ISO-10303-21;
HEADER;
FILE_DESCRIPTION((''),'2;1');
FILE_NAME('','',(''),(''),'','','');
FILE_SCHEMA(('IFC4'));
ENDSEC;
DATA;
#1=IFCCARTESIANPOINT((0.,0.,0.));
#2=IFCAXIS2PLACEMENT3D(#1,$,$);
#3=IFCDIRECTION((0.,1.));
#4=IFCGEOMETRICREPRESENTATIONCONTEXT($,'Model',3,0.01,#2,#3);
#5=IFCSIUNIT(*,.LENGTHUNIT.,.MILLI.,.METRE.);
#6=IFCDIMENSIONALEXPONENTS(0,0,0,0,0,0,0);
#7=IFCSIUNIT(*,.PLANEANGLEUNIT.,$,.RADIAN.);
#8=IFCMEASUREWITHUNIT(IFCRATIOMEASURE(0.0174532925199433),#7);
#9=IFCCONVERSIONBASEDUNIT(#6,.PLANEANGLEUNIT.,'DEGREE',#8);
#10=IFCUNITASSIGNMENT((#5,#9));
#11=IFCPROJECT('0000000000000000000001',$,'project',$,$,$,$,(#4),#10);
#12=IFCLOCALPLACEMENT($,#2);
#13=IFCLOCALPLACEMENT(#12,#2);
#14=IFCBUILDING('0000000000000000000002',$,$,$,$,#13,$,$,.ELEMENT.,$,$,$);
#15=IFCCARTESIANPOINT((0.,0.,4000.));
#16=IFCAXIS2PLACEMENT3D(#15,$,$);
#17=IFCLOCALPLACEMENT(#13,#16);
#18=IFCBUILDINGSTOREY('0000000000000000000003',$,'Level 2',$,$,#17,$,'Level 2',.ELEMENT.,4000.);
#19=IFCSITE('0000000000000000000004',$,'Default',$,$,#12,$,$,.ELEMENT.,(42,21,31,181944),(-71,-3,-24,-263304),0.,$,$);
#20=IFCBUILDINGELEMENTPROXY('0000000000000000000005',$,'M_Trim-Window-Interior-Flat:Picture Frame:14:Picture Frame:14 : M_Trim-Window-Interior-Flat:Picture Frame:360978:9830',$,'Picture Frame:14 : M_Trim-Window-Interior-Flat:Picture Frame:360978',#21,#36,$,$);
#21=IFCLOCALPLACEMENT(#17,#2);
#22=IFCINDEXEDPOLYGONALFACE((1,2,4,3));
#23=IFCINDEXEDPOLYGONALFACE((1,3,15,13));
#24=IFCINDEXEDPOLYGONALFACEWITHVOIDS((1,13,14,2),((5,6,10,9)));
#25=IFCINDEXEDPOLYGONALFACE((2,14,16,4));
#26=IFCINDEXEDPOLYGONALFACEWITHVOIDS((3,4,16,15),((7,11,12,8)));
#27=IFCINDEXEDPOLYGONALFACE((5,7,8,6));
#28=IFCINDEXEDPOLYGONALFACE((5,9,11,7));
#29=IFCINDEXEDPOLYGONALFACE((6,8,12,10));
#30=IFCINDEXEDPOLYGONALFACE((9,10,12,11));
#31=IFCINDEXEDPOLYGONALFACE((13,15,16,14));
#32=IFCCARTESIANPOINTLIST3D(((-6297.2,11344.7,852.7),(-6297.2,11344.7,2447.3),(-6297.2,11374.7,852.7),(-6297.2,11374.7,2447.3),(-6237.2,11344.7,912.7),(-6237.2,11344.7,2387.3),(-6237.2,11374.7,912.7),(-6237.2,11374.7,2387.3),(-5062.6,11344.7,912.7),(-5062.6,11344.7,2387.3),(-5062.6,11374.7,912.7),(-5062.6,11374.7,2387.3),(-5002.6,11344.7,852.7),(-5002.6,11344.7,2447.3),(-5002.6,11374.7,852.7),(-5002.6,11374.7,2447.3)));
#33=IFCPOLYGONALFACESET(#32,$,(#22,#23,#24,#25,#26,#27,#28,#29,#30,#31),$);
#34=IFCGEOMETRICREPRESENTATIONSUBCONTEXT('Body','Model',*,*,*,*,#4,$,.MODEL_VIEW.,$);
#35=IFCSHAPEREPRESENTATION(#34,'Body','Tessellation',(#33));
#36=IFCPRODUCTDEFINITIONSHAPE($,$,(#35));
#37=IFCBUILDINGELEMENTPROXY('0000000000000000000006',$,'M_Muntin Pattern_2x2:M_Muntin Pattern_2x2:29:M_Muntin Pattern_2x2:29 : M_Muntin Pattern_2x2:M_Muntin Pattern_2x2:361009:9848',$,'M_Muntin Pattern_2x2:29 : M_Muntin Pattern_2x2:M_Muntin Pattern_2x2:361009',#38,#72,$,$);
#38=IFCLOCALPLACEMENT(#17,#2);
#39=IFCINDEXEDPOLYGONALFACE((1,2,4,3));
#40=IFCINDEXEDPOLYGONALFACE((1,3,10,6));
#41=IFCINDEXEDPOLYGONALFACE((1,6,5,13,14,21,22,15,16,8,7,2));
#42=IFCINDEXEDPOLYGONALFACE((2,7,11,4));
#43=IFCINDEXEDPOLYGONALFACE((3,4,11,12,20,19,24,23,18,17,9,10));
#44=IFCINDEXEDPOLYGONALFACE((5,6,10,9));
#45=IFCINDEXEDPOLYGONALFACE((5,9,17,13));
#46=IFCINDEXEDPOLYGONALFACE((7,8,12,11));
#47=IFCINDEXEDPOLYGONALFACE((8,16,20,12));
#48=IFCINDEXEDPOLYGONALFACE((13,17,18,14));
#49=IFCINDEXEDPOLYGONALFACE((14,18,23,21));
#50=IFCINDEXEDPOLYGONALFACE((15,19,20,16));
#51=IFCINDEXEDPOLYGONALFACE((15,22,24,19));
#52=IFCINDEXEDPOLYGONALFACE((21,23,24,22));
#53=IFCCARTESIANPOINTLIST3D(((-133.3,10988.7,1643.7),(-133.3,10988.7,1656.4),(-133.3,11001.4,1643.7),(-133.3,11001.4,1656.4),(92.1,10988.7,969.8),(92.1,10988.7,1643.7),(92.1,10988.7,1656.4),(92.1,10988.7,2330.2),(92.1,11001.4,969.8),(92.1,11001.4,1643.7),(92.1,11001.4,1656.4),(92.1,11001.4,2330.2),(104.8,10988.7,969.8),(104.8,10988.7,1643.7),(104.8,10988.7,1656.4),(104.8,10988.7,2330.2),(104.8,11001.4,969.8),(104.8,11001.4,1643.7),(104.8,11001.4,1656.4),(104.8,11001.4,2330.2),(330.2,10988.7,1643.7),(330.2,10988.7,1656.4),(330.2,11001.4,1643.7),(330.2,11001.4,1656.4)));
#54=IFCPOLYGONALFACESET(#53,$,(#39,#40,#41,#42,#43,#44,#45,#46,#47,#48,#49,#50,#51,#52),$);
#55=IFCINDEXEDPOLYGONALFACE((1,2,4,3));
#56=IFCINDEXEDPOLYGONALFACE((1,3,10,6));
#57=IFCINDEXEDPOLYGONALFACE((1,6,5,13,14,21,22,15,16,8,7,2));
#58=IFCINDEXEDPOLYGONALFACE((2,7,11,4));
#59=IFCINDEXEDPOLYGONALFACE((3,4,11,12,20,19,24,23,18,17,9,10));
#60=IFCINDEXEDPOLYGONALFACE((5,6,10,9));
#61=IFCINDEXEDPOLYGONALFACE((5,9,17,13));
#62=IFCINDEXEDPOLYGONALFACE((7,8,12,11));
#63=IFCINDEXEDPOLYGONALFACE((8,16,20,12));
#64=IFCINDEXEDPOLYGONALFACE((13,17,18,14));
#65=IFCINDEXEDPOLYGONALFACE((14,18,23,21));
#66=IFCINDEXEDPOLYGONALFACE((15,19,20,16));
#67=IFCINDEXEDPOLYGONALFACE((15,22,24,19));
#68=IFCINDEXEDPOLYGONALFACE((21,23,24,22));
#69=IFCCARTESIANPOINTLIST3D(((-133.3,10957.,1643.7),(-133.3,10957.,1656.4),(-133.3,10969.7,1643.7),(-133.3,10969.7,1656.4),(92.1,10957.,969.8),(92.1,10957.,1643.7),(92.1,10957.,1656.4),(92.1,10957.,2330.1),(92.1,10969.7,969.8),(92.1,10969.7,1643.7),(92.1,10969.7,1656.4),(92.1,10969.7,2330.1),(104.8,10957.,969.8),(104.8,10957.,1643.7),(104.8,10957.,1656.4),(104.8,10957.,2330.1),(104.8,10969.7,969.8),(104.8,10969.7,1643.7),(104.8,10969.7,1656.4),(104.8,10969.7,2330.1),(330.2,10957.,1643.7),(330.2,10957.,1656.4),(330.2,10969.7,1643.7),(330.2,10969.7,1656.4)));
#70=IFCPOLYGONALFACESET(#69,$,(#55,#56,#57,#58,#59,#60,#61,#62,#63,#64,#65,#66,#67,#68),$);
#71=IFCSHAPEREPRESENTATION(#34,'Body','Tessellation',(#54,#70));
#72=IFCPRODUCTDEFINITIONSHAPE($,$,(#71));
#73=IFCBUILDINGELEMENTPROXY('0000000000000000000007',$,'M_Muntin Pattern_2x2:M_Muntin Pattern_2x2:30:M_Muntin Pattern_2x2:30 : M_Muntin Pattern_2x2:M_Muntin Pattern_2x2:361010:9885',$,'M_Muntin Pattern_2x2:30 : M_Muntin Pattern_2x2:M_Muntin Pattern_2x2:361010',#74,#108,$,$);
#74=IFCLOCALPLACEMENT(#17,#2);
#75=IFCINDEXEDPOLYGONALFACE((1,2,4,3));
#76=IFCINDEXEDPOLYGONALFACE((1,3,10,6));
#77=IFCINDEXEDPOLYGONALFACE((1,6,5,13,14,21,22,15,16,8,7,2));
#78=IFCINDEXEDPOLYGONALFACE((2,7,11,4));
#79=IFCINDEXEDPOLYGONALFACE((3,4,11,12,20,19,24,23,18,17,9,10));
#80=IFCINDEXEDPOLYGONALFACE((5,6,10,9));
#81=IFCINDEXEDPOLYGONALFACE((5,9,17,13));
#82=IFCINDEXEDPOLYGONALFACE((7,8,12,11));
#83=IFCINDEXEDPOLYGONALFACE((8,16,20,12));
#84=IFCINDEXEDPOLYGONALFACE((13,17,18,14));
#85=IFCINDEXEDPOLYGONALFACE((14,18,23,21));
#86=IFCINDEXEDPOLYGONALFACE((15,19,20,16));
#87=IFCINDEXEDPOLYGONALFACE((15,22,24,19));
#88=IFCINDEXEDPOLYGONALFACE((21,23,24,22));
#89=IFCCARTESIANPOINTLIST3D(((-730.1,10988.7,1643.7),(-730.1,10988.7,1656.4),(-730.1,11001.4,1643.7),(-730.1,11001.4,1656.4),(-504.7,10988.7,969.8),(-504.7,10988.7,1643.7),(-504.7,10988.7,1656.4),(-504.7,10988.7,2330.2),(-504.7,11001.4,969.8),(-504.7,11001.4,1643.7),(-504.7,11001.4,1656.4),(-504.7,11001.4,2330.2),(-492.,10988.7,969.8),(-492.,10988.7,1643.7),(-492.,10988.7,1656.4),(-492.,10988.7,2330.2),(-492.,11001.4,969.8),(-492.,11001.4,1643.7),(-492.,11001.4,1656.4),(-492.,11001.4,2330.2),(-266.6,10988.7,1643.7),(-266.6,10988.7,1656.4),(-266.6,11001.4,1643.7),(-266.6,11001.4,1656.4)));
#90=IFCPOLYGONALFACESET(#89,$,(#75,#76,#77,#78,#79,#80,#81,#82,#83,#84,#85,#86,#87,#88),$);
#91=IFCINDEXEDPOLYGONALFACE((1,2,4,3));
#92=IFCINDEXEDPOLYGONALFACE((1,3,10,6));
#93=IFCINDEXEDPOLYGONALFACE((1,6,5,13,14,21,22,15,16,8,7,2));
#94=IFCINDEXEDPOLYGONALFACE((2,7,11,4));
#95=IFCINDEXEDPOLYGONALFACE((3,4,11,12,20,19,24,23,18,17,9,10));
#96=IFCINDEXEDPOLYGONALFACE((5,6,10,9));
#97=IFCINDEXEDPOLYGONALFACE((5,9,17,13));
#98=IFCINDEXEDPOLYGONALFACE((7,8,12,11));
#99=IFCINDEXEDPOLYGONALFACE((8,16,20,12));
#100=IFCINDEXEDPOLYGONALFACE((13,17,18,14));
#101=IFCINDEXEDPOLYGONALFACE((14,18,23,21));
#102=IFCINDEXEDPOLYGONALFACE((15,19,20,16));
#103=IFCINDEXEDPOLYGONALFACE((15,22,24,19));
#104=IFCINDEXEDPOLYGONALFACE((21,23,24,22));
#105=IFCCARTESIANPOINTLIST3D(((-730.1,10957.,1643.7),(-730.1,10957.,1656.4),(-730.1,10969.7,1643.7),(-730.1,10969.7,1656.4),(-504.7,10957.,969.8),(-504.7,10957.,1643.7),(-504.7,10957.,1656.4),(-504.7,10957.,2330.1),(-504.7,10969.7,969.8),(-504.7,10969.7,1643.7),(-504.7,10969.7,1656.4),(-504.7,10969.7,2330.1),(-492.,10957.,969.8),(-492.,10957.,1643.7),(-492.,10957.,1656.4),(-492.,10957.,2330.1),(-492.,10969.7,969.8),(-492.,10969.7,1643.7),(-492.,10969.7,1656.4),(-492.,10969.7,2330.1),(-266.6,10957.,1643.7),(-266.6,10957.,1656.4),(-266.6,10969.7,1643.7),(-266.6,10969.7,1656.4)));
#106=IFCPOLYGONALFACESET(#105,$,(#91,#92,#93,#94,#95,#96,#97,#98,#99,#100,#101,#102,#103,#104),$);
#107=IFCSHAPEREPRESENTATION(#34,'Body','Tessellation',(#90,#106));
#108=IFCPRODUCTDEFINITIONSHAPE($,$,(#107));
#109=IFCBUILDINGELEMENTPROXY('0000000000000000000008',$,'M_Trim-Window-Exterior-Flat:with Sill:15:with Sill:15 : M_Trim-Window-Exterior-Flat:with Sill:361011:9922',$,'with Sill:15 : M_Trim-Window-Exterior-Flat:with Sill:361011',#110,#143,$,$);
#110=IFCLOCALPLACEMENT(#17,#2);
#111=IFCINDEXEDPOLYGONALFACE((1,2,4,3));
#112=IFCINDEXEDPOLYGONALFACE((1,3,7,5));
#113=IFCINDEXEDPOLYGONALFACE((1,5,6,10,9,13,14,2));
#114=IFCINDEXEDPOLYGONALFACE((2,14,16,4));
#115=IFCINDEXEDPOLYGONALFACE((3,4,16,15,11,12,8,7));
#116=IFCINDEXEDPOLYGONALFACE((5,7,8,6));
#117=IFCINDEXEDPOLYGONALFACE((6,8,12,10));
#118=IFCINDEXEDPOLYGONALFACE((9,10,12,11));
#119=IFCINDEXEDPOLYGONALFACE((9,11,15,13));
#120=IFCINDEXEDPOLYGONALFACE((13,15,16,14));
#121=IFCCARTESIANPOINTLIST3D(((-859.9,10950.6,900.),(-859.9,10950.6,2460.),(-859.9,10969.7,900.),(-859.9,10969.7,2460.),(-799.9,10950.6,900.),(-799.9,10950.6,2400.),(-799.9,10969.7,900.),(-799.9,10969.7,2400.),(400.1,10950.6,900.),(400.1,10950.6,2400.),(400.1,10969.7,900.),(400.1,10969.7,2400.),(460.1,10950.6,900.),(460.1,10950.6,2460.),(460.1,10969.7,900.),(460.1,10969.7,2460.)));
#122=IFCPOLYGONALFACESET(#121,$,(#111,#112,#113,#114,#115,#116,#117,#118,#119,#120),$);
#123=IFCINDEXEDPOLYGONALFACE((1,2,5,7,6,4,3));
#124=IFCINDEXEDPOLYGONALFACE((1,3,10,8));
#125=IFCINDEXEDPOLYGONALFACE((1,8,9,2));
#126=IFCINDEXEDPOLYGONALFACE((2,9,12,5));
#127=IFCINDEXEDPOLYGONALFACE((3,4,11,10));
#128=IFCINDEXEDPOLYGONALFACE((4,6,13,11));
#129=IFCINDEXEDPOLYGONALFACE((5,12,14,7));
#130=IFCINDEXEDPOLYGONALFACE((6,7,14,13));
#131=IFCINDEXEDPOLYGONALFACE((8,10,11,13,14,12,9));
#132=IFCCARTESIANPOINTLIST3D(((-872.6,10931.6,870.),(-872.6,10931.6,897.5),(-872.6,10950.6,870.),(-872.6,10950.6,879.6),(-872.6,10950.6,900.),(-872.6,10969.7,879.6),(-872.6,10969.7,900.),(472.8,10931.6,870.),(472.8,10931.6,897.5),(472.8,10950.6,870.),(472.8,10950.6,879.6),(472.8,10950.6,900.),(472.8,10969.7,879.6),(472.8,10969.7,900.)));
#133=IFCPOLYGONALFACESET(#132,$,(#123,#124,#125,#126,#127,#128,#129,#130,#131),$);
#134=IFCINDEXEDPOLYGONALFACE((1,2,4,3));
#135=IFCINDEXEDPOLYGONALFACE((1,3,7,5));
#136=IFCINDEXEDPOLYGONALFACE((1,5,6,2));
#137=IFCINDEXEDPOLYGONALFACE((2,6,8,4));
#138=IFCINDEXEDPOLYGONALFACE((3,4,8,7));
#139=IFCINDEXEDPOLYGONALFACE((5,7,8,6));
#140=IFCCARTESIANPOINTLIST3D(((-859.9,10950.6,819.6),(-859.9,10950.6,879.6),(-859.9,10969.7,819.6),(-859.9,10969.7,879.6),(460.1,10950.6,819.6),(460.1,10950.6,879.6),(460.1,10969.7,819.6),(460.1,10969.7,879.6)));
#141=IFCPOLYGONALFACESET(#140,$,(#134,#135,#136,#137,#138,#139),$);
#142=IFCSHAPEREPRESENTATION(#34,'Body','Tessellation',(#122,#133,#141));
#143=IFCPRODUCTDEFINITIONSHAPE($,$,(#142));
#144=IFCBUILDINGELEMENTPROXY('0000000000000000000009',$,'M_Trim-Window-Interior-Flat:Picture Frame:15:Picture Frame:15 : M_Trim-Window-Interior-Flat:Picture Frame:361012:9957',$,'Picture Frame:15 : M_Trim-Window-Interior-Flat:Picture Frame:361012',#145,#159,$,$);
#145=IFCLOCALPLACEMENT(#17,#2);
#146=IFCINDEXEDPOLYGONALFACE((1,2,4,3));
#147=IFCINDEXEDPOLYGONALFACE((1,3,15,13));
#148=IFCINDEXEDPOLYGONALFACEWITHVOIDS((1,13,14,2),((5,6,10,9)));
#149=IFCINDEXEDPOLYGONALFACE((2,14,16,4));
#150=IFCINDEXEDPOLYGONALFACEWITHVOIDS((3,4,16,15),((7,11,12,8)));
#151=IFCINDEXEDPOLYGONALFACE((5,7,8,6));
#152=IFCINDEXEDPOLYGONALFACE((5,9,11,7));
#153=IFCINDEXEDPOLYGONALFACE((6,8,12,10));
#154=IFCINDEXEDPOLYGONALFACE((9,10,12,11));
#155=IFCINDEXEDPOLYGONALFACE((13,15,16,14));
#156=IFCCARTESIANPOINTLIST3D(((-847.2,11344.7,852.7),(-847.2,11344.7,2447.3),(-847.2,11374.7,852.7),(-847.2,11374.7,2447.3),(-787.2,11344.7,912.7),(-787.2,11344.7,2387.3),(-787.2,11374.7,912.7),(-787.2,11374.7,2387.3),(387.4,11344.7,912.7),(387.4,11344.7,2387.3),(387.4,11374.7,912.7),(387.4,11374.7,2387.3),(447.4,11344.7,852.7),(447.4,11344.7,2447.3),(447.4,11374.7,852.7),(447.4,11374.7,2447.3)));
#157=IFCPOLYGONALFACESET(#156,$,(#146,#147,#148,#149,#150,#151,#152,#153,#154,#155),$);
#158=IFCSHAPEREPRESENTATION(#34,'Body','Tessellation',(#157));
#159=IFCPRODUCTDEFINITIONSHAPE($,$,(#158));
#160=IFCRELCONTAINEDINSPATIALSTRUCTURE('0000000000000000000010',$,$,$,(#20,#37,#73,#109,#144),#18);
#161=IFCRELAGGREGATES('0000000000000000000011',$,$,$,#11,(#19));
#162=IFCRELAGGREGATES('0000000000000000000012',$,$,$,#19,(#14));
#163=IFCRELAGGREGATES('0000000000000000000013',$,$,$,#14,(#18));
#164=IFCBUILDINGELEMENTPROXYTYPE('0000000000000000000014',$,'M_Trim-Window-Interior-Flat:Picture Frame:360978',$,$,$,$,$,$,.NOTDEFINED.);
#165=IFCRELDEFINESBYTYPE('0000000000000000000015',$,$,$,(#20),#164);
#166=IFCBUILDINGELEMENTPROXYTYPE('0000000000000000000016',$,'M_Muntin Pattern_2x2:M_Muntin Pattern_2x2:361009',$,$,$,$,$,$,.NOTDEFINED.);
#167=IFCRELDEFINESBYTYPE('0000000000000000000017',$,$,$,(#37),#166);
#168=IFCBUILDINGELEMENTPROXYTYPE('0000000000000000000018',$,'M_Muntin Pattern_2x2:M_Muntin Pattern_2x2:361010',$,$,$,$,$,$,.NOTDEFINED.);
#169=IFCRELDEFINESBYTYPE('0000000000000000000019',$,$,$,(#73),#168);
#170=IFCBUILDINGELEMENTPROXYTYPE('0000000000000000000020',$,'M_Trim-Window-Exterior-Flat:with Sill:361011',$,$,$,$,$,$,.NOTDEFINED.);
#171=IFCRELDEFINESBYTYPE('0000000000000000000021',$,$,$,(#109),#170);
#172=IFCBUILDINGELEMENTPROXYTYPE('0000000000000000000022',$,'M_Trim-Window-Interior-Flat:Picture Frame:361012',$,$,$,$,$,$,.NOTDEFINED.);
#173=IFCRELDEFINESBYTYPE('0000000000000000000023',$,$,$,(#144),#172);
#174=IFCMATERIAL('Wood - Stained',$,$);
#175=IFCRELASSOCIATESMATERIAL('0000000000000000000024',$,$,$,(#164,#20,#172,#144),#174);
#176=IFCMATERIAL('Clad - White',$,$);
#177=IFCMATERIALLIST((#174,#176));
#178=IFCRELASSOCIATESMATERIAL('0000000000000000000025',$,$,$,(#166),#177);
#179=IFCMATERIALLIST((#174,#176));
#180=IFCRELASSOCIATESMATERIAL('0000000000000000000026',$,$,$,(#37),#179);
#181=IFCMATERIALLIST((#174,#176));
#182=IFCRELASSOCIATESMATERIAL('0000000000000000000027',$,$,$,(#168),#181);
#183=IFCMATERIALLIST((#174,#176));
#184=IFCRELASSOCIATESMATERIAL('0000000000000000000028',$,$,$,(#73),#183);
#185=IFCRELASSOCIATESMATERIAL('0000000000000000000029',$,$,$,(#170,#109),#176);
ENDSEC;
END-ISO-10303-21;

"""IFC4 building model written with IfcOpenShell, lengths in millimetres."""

from ifc_helpers import new_model, entity, si_unit, converted_unit, direction, frame, origin, origin_2d_with_axis, place, context, subcontext, project, spatial, polyline, rectangle, outline, extrude, source, transform, mapped, material, material_list, type_object, type_shapes, element, save


model = new_model("IFC4")

# Units and contexts
model_context = context("Model", 3, precision=0.01, world=origin(), true_north=direction((0.0, 1.0)))
body_context = subcontext(model_context, "Body", "Model", "MODEL_VIEW")
ifc_project = project(units=[si_unit("LENGTHUNIT", "METRE", prefix="MILLI"), converted_unit("PLANEANGLEUNIT", "DEGREE", entity("IfcRatioMeasure", 0.0174532925199433), si_unit("PLANEANGLEUNIT", "RADIAN"), dimensions=[0, 0, 0, 0, 0, 0, 0])], contexts=[model_context])

# Site, building, storey
site_placement = place(None, origin())
site = spatial("IfcSite", under=ifc_project, at=site_placement, Name="Default", CompositionType="ELEMENT", RefLatitude=(42, 21, 31, 181944), RefLongitude=(-71, -3, -24, -263304), RefElevation=0.0)
building_placement = place(site_placement, origin())
building = spatial("IfcBuilding", under=site, at=building_placement, CompositionType="ELEMENT")
storey_placement = place(building_placement, frame((0.0, 0.0, 4000.0)))
storey = spatial("IfcBuildingStorey", under=building, at=storey_placement, Name="Level 2", LongName="Level 2", CompositionType="ELEMENT", Elevation=4000.0)

# Building element proxies
ifc_material_1 = material(Name="Wood - Stained")
ifc_material_2 = material(Name="Clad - White")
building_element_proxy_type_1 = type_object("IfcBuildingElementProxyType", Name="M_Trim-Window-Interior-Flat:Picture Frame:360978", PredefinedType="NOTDEFINED", material=ifc_material_1)
shared_shape_1 = source(origin(), body_context, "Body", "SweptSolid", [
    extrude(outline(polyline([(-797.3, -647.3), (797.3, -647.3), (797.3, 647.3), (-797.3, 647.3), (-797.3, -647.3)]), holes=[polyline([(737.3, 587.3), (737.3, -587.3), (-737.3, -587.3), (-737.3, 587.3), (737.3, 587.3)])]), frame((-5649.9, 11344.7, 5650.0), z_axis=(0.0, 1.0, 0.0), x_axis=(0.0, 0.0, -1.0)), (0.0, 0.0, 1.0), 30.0),
])
type_shapes(building_element_proxy_type_1, [shared_shape_1])
proxy_1_placement = place(storey_placement, frame((0.0, 0.0, -4000.0)))
element("IfcBuildingElementProxy", 1, at=proxy_1_placement, inside=storey, type_object=building_element_proxy_type_1, material=ifc_material_1, Name="M_Trim-Window-Interior-Flat:Picture Frame:14:Picture Frame:14 : M_Trim-Window-Interior-Flat:Picture Frame:360978:9830", ObjectType="Picture Frame:14 : M_Trim-Window-Interior-Flat:Picture Frame:360978", context=body_context, shape_type="MappedRepresentation", body=[
    mapped(shared_shape_1, transform((0.0, 0.0, 0.0), scale=1.0)),
])
ifc_material_list_1 = material_list([ifc_material_1, ifc_material_2])
ifc_material_list_2 = material_list([ifc_material_1, ifc_material_2])
building_element_proxy_type_2 = type_object("IfcBuildingElementProxyType", Name="M_Muntin Pattern_2x2:M_Muntin Pattern_2x2:361009", PredefinedType="NOTDEFINED", material=ifc_material_list_2)
shared_shape_2 = source(origin(), body_context, "Body", "SweptSolid", [
    extrude(outline(polyline([(-680.2, 6.4), (-680.2, -6.3), (-6.4, -6.3), (-6.4, -231.7), (6.3, -231.7), (6.3, -6.3), (680.2, -6.3), (680.2, 6.4), (6.3, 6.4), (6.3, 231.7), (-6.4, 231.7), (-6.4, 6.4), (-680.2, 6.4)])), frame((98.5, 10988.7, 5650.0), z_axis=(0.0, -1.0, 0.0), x_axis=(0.0, 0.0, -1.0)), (0.0, 0.0, -1.0), 12.7),
    extrude(outline(polyline([(-680.1, 6.4), (-680.1, -6.3), (-6.4, -6.3), (-6.4, -231.7), (6.3, -231.7), (6.3, -6.3), (680.2, -6.3), (680.2, 6.4), (6.3, 6.4), (6.3, 231.7), (-6.4, 231.7), (-6.4, 6.4), (-680.1, 6.4)])), frame((98.5, 10957.0, 5650.0), z_axis=(0.0, -1.0, 0.0), x_axis=(0.0, 0.0, -1.0)), (0.0, 0.0, -1.0), 12.7),
])
type_shapes(building_element_proxy_type_2, [shared_shape_2])
proxy_2_placement = place(storey_placement, frame((0.0, 0.0, -4000.0)))
element("IfcBuildingElementProxy", 2, at=proxy_2_placement, inside=storey, type_object=building_element_proxy_type_2, material=ifc_material_list_1, Name="M_Muntin Pattern_2x2:M_Muntin Pattern_2x2:29:M_Muntin Pattern_2x2:29 : M_Muntin Pattern_2x2:M_Muntin Pattern_2x2:361009:9848", ObjectType="M_Muntin Pattern_2x2:29 : M_Muntin Pattern_2x2:M_Muntin Pattern_2x2:361009", context=body_context, shape_type="MappedRepresentation", body=[
    mapped(shared_shape_2, transform((0.0, 0.0, 0.0), scale=1.0)),
])
ifc_material_list_3 = material_list([ifc_material_1, ifc_material_2])
ifc_material_list_4 = material_list([ifc_material_1, ifc_material_2])
building_element_proxy_type_3 = type_object("IfcBuildingElementProxyType", Name="M_Muntin Pattern_2x2:M_Muntin Pattern_2x2:361010", PredefinedType="NOTDEFINED", material=ifc_material_list_4)
shared_shape_3 = source(origin(), body_context, "Body", "SweptSolid", [
    extrude(outline(polyline([(-6.4, -680.1), (6.3, -680.1), (6.3, -6.4), (231.7, -6.4), (231.7, 6.3), (6.3, 6.3), (6.3, 680.2), (-6.4, 680.2), (-6.4, 6.3), (-231.7, 6.3), (-231.7, -6.4), (-6.4, -6.4), (-6.4, -680.1)])), frame((-498.4, 10988.7, 5650.0), z_axis=(0.0, 1.0, 0.0), x_axis=(1.0, 0.0, 0.0)), (0.0, 0.0, 1.0), 12.7),
    extrude(outline(polyline([(-6.4, -680.1), (6.3, -680.1), (6.3, -6.4), (231.7, -6.4), (231.7, 6.3), (6.3, 6.3), (6.3, 680.2), (-6.4, 680.2), (-6.4, 6.3), (-231.7, 6.3), (-231.7, -6.4), (-6.4, -6.4), (-6.4, -680.1)])), frame((-498.4, 10957.0, 5650.0), z_axis=(0.0, 1.0, 0.0), x_axis=(1.0, 0.0, 0.0)), (0.0, 0.0, 1.0), 12.7),
])
type_shapes(building_element_proxy_type_3, [shared_shape_3])
proxy_3_placement = place(storey_placement, frame((0.0, 0.0, -4000.0)))
element("IfcBuildingElementProxy", 3, at=proxy_3_placement, inside=storey, type_object=building_element_proxy_type_3, material=ifc_material_list_3, Name="M_Muntin Pattern_2x2:M_Muntin Pattern_2x2:30:M_Muntin Pattern_2x2:30 : M_Muntin Pattern_2x2:M_Muntin Pattern_2x2:361010:9885", ObjectType="M_Muntin Pattern_2x2:30 : M_Muntin Pattern_2x2:M_Muntin Pattern_2x2:361010", context=body_context, shape_type="MappedRepresentation", body=[
    mapped(shared_shape_3, transform((0.0, 0.0, 0.0), scale=1.0)),
])
building_element_proxy_type_4 = type_object("IfcBuildingElementProxyType", Name="M_Trim-Window-Exterior-Flat:with Sill:361011", PredefinedType="NOTDEFINED", material=ifc_material_2)
shared_shape_4 = source(origin(), body_context, "Body", "SweptSolid", [
    extrude(outline(polyline([(-765.0, -660.0), (795.0, -660.0), (795.0, 660.0), (-765.0, 660.0), (-765.0, 600.0), (735.0, 600.0), (735.0, -600.0), (-765.0, -600.0), (-765.0, -660.0)])), frame((-199.9, 10950.6, 5665.0), z_axis=(0.0, 1.0, 0.0), x_axis=(0.0, 0.0, 1.0)), (0.0, 0.0, 1.0), 19.1),
    extrude(outline(polyline([(-15.2, 0.0), (-15.2, -19.0), (12.3, -19.0), (14.8, 0.0), (14.8, 19.0), (-5.7, 19.0), (-5.7, 0.0), (-15.2, 0.0)])), frame((-872.6, 10950.6, 4885.2), z_axis=(-1.0, 0.0, 0.0), x_axis=(0.0, 0.0, 1.0)), (0.0, 0.0, -1.0), 1345.4),
    extrude(rectangle(XDim=19.1, YDim=1320.0, at=origin_2d_with_axis()), frame((-199.9, 10960.1, 4819.6), z_axis=(0.0, 0.0, 1.0), x_axis=(0.0, 1.0, 0.0)), (0.0, 0.0, 1.0), 60.0),
])
type_shapes(building_element_proxy_type_4, [shared_shape_4])
proxy_4_placement = place(storey_placement, frame((0.0, 0.0, -4000.0)))
element("IfcBuildingElementProxy", 4, at=proxy_4_placement, inside=storey, type_object=building_element_proxy_type_4, material=ifc_material_2, Name="M_Trim-Window-Exterior-Flat:with Sill:15:with Sill:15 : M_Trim-Window-Exterior-Flat:with Sill:361011:9922", ObjectType="with Sill:15 : M_Trim-Window-Exterior-Flat:with Sill:361011", context=body_context, shape_type="MappedRepresentation", body=[
    mapped(shared_shape_4, transform((0.0, 0.0, 0.0), scale=1.0)),
])
building_element_proxy_type_5 = type_object("IfcBuildingElementProxyType", Name="M_Trim-Window-Interior-Flat:Picture Frame:361012", PredefinedType="NOTDEFINED", material=ifc_material_1)
shared_shape_5 = source(origin(), body_context, "Body", "SweptSolid", [
    extrude(outline(polyline([(-797.3, -647.3), (797.3, -647.3), (797.3, 647.3), (-797.3, 647.3), (-797.3, -647.3)]), holes=[polyline([(737.3, 587.3), (737.3, -587.3), (-737.3, -587.3), (-737.3, 587.3), (737.3, 587.3)])]), frame((-199.9, 11344.7, 5650.0), z_axis=(0.0, 1.0, 0.0), x_axis=(0.0, 0.0, -1.0)), (0.0, 0.0, 1.0), 30.0),
])
type_shapes(building_element_proxy_type_5, [shared_shape_5])
proxy_5_placement = place(storey_placement, frame((0.0, 0.0, -4000.0)))
element("IfcBuildingElementProxy", 5, at=proxy_5_placement, inside=storey, type_object=building_element_proxy_type_5, material=ifc_material_1, Name="M_Trim-Window-Interior-Flat:Picture Frame:15:Picture Frame:15 : M_Trim-Window-Interior-Flat:Picture Frame:361012:9957", ObjectType="Picture Frame:15 : M_Trim-Window-Interior-Flat:Picture Frame:361012", context=body_context, shape_type="MappedRepresentation", body=[
    mapped(shared_shape_5, transform((0.0, 0.0, 0.0), scale=1.0)),
])

save(model, "model.ifc")
